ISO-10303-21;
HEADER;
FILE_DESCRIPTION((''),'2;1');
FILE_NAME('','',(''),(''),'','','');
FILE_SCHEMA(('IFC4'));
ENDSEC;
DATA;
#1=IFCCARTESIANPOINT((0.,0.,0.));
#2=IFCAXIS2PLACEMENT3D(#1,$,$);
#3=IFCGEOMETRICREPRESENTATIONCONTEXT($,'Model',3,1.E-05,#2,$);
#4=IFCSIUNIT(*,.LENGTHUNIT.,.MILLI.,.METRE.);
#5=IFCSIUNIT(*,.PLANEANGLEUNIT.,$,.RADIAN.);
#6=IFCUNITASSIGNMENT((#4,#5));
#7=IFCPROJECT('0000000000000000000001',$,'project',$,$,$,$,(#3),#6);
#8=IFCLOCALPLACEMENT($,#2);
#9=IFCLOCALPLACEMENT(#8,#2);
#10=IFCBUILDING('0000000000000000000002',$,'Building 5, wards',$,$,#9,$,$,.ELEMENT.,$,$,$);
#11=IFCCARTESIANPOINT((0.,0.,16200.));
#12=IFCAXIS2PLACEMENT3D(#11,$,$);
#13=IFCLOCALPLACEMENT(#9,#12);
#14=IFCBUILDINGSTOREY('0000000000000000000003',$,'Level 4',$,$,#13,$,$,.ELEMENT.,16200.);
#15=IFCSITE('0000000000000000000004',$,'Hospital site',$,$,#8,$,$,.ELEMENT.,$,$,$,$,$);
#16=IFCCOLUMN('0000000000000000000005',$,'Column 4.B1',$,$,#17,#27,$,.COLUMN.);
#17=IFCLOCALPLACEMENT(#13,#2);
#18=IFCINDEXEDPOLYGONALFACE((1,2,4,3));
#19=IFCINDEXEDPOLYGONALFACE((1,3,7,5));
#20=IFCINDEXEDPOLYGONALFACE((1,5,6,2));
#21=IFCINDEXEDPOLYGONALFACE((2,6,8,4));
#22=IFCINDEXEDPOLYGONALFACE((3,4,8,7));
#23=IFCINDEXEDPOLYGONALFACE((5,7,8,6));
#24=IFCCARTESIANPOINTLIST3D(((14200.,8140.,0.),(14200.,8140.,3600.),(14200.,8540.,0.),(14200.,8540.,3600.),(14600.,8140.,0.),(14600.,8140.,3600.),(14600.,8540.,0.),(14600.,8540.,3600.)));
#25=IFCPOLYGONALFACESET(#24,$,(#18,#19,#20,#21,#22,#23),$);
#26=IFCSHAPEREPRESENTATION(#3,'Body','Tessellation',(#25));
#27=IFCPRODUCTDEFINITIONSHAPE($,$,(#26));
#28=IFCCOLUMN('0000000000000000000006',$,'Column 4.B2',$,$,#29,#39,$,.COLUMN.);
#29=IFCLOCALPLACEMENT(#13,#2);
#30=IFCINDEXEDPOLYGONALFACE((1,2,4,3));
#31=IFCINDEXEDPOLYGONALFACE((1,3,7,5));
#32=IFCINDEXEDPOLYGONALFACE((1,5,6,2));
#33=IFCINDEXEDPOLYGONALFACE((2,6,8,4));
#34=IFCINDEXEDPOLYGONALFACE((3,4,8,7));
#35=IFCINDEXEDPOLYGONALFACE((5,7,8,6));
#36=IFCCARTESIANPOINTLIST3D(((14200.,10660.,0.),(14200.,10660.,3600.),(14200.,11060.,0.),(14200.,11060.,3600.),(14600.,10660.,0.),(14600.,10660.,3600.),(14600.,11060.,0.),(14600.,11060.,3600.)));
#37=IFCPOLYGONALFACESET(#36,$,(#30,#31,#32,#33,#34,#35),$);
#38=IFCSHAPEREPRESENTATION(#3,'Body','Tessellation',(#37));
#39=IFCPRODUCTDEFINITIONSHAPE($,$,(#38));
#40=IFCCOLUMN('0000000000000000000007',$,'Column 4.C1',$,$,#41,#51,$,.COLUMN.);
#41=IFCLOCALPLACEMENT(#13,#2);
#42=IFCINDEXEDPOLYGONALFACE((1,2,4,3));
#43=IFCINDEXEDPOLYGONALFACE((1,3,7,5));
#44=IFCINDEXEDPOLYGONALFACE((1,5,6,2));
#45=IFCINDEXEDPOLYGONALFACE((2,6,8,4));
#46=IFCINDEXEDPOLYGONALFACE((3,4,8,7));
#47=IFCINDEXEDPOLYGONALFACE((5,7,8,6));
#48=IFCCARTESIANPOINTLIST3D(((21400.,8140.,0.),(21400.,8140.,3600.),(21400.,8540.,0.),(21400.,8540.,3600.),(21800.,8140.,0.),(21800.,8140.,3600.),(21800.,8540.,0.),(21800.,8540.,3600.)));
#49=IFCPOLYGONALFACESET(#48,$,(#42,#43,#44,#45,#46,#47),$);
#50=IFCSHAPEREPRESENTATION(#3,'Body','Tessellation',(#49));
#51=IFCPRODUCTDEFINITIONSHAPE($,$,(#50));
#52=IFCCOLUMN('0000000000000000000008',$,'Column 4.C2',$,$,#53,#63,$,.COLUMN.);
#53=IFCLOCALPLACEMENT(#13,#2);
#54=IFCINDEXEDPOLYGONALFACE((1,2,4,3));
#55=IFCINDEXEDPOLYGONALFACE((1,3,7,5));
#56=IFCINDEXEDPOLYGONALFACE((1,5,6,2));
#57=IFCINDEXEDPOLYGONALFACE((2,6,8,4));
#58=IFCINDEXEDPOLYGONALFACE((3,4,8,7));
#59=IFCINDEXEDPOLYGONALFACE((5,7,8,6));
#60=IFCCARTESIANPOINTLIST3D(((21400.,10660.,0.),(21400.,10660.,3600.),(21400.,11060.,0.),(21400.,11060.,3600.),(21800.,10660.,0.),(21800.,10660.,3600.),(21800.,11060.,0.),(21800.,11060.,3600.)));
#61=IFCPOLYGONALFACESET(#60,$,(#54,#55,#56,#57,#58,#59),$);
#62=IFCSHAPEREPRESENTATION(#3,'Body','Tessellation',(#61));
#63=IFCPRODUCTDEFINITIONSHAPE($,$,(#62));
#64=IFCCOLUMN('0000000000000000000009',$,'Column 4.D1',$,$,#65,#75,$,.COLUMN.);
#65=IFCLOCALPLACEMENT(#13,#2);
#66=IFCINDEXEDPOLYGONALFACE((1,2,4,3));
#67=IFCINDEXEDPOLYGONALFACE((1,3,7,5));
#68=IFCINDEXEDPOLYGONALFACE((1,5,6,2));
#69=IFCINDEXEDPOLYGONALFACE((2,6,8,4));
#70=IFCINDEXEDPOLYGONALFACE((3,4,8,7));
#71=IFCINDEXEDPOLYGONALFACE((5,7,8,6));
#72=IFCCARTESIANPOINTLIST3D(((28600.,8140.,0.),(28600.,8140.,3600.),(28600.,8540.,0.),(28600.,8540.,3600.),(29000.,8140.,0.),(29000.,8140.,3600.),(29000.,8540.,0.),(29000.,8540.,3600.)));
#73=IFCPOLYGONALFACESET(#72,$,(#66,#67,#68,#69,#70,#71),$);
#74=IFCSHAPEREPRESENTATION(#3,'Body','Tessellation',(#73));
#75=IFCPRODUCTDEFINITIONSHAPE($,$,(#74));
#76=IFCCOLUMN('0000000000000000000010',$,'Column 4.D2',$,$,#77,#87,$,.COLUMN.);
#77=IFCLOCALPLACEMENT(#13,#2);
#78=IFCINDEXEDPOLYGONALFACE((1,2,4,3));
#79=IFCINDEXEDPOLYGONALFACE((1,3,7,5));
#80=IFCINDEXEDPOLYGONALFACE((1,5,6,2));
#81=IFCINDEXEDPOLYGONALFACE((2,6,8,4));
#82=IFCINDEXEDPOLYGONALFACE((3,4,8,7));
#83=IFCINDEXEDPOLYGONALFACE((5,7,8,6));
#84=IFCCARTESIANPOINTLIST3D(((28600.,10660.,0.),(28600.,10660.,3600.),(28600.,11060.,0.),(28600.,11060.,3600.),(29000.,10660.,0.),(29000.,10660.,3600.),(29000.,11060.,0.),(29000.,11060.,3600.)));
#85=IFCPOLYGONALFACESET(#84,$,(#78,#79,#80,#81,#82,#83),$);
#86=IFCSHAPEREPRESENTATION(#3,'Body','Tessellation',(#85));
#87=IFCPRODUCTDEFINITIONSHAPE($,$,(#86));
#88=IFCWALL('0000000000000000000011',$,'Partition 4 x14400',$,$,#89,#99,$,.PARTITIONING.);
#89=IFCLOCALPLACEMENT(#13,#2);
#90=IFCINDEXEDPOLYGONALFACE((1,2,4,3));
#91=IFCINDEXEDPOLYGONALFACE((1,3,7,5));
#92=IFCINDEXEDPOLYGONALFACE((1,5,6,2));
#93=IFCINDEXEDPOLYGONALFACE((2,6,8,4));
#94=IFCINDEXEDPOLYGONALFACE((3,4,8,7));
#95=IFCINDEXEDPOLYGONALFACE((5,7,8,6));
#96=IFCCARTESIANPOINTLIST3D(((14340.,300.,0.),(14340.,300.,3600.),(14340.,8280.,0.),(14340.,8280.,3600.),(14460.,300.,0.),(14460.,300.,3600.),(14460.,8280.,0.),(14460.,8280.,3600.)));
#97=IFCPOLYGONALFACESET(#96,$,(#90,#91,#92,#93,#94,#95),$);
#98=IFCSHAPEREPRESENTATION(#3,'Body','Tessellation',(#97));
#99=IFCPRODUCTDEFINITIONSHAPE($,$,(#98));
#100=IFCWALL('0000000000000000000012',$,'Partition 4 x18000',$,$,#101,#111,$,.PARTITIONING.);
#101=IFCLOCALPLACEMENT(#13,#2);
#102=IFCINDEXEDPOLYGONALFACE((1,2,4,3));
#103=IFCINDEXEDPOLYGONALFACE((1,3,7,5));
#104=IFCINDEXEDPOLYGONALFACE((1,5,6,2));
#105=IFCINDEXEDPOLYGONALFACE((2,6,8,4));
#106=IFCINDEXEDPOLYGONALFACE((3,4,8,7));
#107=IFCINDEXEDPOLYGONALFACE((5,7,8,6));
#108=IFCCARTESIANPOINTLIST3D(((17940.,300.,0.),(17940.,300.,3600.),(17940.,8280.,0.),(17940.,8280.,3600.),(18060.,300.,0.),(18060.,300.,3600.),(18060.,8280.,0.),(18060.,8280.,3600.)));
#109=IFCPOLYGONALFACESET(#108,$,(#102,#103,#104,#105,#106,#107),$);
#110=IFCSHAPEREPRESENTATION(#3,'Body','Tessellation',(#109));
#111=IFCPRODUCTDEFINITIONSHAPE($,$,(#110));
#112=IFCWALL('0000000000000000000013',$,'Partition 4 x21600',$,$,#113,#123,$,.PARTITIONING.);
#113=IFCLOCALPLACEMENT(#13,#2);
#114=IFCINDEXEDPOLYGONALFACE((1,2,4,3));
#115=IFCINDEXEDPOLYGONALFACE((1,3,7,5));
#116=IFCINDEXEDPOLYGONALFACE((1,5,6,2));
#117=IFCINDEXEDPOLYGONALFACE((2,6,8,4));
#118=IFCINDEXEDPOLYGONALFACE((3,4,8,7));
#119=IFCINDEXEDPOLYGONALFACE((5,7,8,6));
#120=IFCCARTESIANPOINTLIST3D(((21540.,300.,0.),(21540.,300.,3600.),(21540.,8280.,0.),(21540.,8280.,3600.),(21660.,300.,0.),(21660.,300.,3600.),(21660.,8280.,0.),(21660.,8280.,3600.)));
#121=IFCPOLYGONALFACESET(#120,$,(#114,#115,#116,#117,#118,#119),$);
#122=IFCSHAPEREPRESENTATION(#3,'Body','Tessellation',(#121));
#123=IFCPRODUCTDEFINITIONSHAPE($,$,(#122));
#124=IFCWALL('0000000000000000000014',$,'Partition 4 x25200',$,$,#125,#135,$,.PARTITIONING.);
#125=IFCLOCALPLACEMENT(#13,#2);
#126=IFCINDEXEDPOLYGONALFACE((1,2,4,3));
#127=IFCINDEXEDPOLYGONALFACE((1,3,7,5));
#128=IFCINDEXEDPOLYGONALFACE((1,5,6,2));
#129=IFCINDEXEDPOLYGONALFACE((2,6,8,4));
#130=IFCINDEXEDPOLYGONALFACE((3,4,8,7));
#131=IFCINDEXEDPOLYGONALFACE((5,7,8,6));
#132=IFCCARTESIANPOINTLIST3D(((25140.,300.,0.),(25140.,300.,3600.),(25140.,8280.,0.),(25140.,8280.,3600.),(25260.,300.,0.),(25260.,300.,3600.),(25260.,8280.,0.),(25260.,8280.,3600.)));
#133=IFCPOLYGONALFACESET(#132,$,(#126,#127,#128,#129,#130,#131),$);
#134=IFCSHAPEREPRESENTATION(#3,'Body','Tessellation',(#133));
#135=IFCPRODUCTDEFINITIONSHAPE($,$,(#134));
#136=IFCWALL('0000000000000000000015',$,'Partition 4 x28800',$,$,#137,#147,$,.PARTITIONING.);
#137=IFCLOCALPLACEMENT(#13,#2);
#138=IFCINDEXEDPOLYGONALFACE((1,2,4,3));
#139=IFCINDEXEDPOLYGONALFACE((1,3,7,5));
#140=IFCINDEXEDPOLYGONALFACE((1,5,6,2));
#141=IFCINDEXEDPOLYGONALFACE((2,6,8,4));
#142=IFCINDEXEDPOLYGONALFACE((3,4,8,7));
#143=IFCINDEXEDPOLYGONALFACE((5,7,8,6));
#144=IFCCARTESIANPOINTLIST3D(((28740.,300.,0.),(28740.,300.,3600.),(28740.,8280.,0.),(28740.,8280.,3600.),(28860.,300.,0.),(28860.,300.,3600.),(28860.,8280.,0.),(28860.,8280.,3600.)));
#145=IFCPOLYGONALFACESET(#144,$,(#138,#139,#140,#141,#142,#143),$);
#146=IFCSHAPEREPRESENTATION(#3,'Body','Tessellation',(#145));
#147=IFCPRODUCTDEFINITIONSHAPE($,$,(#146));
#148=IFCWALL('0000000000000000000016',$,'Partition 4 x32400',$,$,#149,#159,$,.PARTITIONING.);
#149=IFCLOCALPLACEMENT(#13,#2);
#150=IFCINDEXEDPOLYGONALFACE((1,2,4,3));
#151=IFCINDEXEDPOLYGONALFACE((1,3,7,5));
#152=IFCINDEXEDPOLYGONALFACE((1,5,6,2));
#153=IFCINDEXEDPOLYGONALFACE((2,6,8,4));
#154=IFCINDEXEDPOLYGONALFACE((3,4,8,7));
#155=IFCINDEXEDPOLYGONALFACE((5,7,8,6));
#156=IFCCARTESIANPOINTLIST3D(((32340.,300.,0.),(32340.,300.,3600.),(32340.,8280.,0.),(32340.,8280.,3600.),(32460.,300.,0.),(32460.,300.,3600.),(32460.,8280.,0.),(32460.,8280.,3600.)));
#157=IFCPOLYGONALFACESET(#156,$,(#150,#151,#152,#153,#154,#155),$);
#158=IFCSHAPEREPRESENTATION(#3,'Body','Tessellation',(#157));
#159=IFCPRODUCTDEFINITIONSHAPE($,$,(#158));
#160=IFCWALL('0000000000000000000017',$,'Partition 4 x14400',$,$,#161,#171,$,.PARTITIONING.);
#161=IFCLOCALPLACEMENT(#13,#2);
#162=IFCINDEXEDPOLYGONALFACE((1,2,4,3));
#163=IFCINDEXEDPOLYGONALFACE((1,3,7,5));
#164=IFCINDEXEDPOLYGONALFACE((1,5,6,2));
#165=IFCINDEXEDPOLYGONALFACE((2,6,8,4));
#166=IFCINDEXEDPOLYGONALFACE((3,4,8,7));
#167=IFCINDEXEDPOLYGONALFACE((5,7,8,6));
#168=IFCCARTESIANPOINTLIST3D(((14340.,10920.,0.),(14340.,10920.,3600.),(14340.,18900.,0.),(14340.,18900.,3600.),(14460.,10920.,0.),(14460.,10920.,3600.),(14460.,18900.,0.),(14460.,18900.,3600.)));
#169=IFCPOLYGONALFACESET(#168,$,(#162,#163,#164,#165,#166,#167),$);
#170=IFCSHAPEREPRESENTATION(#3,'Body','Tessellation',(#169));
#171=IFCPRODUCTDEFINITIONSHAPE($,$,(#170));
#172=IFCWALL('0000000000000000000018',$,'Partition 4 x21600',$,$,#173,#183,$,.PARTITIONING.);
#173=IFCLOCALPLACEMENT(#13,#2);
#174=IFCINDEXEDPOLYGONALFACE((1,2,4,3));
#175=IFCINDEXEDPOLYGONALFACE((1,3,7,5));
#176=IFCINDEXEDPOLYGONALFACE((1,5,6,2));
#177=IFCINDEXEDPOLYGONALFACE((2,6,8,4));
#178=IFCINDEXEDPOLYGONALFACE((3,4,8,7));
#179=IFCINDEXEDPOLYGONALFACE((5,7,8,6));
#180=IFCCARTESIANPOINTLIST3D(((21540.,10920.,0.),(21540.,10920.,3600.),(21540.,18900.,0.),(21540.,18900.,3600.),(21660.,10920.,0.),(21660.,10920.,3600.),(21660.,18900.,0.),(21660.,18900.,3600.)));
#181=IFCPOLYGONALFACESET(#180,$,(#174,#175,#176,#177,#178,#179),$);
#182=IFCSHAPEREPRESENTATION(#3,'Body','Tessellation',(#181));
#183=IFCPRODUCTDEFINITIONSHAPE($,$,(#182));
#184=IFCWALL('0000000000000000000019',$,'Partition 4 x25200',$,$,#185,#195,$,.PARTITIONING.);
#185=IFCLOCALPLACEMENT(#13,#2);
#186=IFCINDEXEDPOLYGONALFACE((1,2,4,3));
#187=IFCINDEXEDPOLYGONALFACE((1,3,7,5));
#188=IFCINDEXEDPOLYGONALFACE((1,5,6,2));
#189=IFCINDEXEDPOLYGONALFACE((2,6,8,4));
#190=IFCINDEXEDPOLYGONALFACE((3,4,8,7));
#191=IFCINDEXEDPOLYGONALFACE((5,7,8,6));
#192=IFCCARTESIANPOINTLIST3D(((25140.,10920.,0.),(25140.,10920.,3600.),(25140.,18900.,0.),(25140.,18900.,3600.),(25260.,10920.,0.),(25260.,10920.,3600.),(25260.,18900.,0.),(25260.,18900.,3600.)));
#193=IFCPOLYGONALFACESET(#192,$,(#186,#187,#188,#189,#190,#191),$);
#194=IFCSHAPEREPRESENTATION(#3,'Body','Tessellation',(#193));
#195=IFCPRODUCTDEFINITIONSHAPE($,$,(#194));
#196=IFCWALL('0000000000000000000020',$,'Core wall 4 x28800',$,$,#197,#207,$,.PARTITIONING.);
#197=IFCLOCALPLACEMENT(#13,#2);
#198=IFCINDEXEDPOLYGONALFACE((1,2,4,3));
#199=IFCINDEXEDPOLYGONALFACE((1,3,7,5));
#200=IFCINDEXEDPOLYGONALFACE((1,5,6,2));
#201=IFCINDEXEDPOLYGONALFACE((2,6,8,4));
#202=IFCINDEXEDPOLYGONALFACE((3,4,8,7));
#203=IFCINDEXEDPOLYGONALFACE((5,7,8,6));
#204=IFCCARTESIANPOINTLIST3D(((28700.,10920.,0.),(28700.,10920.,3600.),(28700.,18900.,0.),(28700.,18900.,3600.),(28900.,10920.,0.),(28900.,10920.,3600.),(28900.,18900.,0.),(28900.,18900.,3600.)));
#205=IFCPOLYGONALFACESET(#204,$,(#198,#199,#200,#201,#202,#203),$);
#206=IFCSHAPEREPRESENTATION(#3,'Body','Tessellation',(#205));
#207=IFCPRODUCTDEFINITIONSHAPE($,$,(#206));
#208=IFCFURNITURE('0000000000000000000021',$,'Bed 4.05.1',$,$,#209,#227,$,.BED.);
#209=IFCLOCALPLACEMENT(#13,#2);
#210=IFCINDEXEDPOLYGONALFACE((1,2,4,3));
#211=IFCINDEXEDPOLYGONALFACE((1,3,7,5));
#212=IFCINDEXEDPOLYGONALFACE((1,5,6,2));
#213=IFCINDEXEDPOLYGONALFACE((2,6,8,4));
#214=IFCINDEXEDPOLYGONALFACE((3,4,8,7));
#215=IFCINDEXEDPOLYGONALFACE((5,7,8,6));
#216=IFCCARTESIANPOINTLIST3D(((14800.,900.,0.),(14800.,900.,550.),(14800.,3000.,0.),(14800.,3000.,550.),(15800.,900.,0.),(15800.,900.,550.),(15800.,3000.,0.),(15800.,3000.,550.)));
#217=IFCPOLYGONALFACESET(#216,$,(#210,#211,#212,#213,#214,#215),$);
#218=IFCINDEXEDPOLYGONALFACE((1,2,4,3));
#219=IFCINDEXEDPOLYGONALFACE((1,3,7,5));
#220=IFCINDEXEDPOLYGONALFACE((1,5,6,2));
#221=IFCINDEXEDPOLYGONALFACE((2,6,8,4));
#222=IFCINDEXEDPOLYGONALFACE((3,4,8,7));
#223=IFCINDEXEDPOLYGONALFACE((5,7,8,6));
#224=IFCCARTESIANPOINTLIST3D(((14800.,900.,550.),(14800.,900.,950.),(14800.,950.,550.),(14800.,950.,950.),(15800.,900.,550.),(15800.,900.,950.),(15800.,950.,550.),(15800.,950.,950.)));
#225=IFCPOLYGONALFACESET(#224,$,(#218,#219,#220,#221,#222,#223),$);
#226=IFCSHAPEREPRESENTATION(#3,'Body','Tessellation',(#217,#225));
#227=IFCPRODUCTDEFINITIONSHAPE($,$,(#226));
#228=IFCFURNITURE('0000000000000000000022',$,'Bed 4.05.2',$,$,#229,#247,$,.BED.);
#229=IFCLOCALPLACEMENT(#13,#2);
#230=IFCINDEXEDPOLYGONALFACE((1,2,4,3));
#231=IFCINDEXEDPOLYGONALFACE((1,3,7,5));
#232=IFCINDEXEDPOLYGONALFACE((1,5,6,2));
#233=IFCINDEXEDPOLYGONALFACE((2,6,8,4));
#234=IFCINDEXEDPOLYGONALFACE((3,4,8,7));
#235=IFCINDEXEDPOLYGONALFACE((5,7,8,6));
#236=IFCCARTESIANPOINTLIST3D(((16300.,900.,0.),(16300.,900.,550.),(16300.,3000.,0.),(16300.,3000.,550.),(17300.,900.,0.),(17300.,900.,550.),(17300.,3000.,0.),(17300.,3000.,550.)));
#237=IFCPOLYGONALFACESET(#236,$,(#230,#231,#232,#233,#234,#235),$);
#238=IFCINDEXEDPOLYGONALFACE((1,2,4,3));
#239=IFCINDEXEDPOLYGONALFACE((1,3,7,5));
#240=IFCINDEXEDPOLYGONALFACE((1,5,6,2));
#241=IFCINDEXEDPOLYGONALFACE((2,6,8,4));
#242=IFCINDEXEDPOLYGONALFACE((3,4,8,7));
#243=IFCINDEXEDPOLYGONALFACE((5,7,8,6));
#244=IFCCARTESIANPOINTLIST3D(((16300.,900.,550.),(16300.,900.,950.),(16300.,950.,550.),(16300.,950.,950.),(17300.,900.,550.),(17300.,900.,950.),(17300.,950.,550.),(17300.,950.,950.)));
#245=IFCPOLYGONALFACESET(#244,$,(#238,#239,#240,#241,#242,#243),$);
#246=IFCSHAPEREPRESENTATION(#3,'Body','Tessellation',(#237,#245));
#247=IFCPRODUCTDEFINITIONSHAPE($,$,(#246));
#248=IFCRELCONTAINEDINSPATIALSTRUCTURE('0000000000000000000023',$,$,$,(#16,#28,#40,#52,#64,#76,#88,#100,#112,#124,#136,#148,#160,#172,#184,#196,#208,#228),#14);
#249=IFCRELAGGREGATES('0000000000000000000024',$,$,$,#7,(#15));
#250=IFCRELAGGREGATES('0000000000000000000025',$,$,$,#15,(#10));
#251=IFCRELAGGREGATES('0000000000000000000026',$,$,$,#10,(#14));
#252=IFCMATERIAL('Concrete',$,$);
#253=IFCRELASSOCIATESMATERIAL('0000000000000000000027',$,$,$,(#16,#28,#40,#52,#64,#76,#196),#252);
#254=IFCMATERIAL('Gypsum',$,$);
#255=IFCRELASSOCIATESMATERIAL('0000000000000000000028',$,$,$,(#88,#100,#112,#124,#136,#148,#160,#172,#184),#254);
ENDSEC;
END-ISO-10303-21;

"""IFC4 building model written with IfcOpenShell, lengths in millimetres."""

from ifc_helpers import new_model, si_unit, frame, frame_2d, origin, origin_2d, place, context, project, spatial, rectangle, extrude, material, element, save


model = new_model("IFC4")

# Units and contexts
model_context = context("Model", 3, precision=1e-05, world=origin())
ifc_project = project(units=[si_unit("LENGTHUNIT", "METRE", prefix="MILLI"), si_unit("PLANEANGLEUNIT", "RADIAN")], contexts=[model_context])

# Site, building, storey
site_placement = place(None, origin())
site = spatial("IfcSite", under=ifc_project, at=site_placement, Name="Hospital site", CompositionType="ELEMENT")
building_placement = place(site_placement, origin())
building = spatial("IfcBuilding", under=site, at=building_placement, Name="Building 5, wards", CompositionType="ELEMENT")
storey_placement = place(building_placement, frame((0.0, 0.0, 16200.0)))
storey = spatial("IfcBuildingStorey", under=building, at=storey_placement, Name="Level 4", CompositionType="ELEMENT", Elevation=16200.0)

# Columns
ifc_material_1 = material(Name="Concrete")
for number, where, name in (
    (1, (14400.0, 8340.0, 0.0), "Column 4.B1"),
    (2, (14400.0, 10860.0, 0.0), "Column 4.B2"),
    (3, (21600.0, 8340.0, 0.0), "Column 4.C1"),
    (4, (21600.0, 10860.0, 0.0), "Column 4.C2"),
    (5, (28800.0, 8340.0, 0.0), "Column 4.D1"),
    (6, (28800.0, 10860.0, 0.0), "Column 4.D2"),
):
    element("IfcColumn", number, at=place(storey_placement, frame(where)), inside=storey, material=ifc_material_1, Name=name, PredefinedType="COLUMN", context=model_context, shape_type="SweptSolid", body=[
        extrude(rectangle(XDim=400.0, YDim=400.0, at=origin_2d()), origin(), (0.0, 0.0, 1.0), 3600.0),
    ])

# Walls
ifc_material_2 = material(Name="Gypsum")
for number, where, x_axis, name in (
    (7, (14460.0, 300.0, 0.0), (0.0, 1.0, 0.0), "Partition 4 x14400"),
    (8, (18060.0, 300.0, 0.0), (0.0, 1.0, 0.0), "Partition 4 x18000"),
    (9, (21660.0, 300.0, 0.0), (0.0, 1.0, 0.0), "Partition 4 x21600"),
    (10, (25260.0, 300.0, 0.0), (0.0, 1.0, 0.0), "Partition 4 x25200"),
    (11, (28860.0, 300.0, 0.0), (0.0, 1.0, 0.0), "Partition 4 x28800"),
    (12, (32460.0, 300.0, 0.0), (0.0, 1.0, 0.0), "Partition 4 x32400"),
    (13, (14460.0, 10920.0, 0.0), (0.0, 1.0, 0.0), "Partition 4 x14400"),
    (14, (21660.0, 10920.0, 0.0), (0.0, 1.0, 0.0), "Partition 4 x21600"),
    (15, (25260.0, 10920.0, 0.0), (0.0, 1.0, 0.0), "Partition 4 x25200"),
):
    element("IfcWall", number, at=place(storey_placement, frame(where, x_axis=x_axis)), inside=storey, material=ifc_material_2, Name=name, PredefinedType="PARTITIONING", context=model_context, shape_type="SweptSolid", body=[
        extrude(rectangle(XDim=7980.0, YDim=120.0, at=frame_2d((3990.0, 60.0))), origin(), (0.0, 0.0, 1.0), 3600.0),
    ])
wall_placement = place(storey_placement, frame((28900.0, 10920.0, 0.0), x_axis=(0.0, 1.0, 0.0)))
element("IfcWall", 16, at=wall_placement, inside=storey, material=ifc_material_1, Name="Core wall 4 x28800", PredefinedType="PARTITIONING", context=model_context, shape_type="SweptSolid", body=[
    extrude(rectangle(XDim=7980.0, YDim=200.0, at=frame_2d((3990.0, 100.0))), origin(), (0.0, 0.0, 1.0), 3600.0),
])

# Furniture
for number, where, name in (
    (17, (14800.0, 900.0, 0.0), "Bed 4.05.1"),
    (18, (16300.0, 900.0, 0.0), "Bed 4.05.2"),
):
    element("IfcFurniture", number, at=place(storey_placement, frame(where)), inside=storey, Name=name, PredefinedType="BED", context=model_context, shape_type="SweptSolid", body=[
        extrude(rectangle(XDim=1000.0, YDim=2100.0, at=frame_2d((500.0, 1050.0))), origin(), (0.0, 0.0, 1.0), 550.0),
        extrude(rectangle(XDim=1000.0, YDim=50.0, at=frame_2d((500.0, 25.0))), frame((0.0, 0.0, 550.0)), (0.0, 0.0, 1.0), 400.0),
    ])

save(model, "model.ifc")
